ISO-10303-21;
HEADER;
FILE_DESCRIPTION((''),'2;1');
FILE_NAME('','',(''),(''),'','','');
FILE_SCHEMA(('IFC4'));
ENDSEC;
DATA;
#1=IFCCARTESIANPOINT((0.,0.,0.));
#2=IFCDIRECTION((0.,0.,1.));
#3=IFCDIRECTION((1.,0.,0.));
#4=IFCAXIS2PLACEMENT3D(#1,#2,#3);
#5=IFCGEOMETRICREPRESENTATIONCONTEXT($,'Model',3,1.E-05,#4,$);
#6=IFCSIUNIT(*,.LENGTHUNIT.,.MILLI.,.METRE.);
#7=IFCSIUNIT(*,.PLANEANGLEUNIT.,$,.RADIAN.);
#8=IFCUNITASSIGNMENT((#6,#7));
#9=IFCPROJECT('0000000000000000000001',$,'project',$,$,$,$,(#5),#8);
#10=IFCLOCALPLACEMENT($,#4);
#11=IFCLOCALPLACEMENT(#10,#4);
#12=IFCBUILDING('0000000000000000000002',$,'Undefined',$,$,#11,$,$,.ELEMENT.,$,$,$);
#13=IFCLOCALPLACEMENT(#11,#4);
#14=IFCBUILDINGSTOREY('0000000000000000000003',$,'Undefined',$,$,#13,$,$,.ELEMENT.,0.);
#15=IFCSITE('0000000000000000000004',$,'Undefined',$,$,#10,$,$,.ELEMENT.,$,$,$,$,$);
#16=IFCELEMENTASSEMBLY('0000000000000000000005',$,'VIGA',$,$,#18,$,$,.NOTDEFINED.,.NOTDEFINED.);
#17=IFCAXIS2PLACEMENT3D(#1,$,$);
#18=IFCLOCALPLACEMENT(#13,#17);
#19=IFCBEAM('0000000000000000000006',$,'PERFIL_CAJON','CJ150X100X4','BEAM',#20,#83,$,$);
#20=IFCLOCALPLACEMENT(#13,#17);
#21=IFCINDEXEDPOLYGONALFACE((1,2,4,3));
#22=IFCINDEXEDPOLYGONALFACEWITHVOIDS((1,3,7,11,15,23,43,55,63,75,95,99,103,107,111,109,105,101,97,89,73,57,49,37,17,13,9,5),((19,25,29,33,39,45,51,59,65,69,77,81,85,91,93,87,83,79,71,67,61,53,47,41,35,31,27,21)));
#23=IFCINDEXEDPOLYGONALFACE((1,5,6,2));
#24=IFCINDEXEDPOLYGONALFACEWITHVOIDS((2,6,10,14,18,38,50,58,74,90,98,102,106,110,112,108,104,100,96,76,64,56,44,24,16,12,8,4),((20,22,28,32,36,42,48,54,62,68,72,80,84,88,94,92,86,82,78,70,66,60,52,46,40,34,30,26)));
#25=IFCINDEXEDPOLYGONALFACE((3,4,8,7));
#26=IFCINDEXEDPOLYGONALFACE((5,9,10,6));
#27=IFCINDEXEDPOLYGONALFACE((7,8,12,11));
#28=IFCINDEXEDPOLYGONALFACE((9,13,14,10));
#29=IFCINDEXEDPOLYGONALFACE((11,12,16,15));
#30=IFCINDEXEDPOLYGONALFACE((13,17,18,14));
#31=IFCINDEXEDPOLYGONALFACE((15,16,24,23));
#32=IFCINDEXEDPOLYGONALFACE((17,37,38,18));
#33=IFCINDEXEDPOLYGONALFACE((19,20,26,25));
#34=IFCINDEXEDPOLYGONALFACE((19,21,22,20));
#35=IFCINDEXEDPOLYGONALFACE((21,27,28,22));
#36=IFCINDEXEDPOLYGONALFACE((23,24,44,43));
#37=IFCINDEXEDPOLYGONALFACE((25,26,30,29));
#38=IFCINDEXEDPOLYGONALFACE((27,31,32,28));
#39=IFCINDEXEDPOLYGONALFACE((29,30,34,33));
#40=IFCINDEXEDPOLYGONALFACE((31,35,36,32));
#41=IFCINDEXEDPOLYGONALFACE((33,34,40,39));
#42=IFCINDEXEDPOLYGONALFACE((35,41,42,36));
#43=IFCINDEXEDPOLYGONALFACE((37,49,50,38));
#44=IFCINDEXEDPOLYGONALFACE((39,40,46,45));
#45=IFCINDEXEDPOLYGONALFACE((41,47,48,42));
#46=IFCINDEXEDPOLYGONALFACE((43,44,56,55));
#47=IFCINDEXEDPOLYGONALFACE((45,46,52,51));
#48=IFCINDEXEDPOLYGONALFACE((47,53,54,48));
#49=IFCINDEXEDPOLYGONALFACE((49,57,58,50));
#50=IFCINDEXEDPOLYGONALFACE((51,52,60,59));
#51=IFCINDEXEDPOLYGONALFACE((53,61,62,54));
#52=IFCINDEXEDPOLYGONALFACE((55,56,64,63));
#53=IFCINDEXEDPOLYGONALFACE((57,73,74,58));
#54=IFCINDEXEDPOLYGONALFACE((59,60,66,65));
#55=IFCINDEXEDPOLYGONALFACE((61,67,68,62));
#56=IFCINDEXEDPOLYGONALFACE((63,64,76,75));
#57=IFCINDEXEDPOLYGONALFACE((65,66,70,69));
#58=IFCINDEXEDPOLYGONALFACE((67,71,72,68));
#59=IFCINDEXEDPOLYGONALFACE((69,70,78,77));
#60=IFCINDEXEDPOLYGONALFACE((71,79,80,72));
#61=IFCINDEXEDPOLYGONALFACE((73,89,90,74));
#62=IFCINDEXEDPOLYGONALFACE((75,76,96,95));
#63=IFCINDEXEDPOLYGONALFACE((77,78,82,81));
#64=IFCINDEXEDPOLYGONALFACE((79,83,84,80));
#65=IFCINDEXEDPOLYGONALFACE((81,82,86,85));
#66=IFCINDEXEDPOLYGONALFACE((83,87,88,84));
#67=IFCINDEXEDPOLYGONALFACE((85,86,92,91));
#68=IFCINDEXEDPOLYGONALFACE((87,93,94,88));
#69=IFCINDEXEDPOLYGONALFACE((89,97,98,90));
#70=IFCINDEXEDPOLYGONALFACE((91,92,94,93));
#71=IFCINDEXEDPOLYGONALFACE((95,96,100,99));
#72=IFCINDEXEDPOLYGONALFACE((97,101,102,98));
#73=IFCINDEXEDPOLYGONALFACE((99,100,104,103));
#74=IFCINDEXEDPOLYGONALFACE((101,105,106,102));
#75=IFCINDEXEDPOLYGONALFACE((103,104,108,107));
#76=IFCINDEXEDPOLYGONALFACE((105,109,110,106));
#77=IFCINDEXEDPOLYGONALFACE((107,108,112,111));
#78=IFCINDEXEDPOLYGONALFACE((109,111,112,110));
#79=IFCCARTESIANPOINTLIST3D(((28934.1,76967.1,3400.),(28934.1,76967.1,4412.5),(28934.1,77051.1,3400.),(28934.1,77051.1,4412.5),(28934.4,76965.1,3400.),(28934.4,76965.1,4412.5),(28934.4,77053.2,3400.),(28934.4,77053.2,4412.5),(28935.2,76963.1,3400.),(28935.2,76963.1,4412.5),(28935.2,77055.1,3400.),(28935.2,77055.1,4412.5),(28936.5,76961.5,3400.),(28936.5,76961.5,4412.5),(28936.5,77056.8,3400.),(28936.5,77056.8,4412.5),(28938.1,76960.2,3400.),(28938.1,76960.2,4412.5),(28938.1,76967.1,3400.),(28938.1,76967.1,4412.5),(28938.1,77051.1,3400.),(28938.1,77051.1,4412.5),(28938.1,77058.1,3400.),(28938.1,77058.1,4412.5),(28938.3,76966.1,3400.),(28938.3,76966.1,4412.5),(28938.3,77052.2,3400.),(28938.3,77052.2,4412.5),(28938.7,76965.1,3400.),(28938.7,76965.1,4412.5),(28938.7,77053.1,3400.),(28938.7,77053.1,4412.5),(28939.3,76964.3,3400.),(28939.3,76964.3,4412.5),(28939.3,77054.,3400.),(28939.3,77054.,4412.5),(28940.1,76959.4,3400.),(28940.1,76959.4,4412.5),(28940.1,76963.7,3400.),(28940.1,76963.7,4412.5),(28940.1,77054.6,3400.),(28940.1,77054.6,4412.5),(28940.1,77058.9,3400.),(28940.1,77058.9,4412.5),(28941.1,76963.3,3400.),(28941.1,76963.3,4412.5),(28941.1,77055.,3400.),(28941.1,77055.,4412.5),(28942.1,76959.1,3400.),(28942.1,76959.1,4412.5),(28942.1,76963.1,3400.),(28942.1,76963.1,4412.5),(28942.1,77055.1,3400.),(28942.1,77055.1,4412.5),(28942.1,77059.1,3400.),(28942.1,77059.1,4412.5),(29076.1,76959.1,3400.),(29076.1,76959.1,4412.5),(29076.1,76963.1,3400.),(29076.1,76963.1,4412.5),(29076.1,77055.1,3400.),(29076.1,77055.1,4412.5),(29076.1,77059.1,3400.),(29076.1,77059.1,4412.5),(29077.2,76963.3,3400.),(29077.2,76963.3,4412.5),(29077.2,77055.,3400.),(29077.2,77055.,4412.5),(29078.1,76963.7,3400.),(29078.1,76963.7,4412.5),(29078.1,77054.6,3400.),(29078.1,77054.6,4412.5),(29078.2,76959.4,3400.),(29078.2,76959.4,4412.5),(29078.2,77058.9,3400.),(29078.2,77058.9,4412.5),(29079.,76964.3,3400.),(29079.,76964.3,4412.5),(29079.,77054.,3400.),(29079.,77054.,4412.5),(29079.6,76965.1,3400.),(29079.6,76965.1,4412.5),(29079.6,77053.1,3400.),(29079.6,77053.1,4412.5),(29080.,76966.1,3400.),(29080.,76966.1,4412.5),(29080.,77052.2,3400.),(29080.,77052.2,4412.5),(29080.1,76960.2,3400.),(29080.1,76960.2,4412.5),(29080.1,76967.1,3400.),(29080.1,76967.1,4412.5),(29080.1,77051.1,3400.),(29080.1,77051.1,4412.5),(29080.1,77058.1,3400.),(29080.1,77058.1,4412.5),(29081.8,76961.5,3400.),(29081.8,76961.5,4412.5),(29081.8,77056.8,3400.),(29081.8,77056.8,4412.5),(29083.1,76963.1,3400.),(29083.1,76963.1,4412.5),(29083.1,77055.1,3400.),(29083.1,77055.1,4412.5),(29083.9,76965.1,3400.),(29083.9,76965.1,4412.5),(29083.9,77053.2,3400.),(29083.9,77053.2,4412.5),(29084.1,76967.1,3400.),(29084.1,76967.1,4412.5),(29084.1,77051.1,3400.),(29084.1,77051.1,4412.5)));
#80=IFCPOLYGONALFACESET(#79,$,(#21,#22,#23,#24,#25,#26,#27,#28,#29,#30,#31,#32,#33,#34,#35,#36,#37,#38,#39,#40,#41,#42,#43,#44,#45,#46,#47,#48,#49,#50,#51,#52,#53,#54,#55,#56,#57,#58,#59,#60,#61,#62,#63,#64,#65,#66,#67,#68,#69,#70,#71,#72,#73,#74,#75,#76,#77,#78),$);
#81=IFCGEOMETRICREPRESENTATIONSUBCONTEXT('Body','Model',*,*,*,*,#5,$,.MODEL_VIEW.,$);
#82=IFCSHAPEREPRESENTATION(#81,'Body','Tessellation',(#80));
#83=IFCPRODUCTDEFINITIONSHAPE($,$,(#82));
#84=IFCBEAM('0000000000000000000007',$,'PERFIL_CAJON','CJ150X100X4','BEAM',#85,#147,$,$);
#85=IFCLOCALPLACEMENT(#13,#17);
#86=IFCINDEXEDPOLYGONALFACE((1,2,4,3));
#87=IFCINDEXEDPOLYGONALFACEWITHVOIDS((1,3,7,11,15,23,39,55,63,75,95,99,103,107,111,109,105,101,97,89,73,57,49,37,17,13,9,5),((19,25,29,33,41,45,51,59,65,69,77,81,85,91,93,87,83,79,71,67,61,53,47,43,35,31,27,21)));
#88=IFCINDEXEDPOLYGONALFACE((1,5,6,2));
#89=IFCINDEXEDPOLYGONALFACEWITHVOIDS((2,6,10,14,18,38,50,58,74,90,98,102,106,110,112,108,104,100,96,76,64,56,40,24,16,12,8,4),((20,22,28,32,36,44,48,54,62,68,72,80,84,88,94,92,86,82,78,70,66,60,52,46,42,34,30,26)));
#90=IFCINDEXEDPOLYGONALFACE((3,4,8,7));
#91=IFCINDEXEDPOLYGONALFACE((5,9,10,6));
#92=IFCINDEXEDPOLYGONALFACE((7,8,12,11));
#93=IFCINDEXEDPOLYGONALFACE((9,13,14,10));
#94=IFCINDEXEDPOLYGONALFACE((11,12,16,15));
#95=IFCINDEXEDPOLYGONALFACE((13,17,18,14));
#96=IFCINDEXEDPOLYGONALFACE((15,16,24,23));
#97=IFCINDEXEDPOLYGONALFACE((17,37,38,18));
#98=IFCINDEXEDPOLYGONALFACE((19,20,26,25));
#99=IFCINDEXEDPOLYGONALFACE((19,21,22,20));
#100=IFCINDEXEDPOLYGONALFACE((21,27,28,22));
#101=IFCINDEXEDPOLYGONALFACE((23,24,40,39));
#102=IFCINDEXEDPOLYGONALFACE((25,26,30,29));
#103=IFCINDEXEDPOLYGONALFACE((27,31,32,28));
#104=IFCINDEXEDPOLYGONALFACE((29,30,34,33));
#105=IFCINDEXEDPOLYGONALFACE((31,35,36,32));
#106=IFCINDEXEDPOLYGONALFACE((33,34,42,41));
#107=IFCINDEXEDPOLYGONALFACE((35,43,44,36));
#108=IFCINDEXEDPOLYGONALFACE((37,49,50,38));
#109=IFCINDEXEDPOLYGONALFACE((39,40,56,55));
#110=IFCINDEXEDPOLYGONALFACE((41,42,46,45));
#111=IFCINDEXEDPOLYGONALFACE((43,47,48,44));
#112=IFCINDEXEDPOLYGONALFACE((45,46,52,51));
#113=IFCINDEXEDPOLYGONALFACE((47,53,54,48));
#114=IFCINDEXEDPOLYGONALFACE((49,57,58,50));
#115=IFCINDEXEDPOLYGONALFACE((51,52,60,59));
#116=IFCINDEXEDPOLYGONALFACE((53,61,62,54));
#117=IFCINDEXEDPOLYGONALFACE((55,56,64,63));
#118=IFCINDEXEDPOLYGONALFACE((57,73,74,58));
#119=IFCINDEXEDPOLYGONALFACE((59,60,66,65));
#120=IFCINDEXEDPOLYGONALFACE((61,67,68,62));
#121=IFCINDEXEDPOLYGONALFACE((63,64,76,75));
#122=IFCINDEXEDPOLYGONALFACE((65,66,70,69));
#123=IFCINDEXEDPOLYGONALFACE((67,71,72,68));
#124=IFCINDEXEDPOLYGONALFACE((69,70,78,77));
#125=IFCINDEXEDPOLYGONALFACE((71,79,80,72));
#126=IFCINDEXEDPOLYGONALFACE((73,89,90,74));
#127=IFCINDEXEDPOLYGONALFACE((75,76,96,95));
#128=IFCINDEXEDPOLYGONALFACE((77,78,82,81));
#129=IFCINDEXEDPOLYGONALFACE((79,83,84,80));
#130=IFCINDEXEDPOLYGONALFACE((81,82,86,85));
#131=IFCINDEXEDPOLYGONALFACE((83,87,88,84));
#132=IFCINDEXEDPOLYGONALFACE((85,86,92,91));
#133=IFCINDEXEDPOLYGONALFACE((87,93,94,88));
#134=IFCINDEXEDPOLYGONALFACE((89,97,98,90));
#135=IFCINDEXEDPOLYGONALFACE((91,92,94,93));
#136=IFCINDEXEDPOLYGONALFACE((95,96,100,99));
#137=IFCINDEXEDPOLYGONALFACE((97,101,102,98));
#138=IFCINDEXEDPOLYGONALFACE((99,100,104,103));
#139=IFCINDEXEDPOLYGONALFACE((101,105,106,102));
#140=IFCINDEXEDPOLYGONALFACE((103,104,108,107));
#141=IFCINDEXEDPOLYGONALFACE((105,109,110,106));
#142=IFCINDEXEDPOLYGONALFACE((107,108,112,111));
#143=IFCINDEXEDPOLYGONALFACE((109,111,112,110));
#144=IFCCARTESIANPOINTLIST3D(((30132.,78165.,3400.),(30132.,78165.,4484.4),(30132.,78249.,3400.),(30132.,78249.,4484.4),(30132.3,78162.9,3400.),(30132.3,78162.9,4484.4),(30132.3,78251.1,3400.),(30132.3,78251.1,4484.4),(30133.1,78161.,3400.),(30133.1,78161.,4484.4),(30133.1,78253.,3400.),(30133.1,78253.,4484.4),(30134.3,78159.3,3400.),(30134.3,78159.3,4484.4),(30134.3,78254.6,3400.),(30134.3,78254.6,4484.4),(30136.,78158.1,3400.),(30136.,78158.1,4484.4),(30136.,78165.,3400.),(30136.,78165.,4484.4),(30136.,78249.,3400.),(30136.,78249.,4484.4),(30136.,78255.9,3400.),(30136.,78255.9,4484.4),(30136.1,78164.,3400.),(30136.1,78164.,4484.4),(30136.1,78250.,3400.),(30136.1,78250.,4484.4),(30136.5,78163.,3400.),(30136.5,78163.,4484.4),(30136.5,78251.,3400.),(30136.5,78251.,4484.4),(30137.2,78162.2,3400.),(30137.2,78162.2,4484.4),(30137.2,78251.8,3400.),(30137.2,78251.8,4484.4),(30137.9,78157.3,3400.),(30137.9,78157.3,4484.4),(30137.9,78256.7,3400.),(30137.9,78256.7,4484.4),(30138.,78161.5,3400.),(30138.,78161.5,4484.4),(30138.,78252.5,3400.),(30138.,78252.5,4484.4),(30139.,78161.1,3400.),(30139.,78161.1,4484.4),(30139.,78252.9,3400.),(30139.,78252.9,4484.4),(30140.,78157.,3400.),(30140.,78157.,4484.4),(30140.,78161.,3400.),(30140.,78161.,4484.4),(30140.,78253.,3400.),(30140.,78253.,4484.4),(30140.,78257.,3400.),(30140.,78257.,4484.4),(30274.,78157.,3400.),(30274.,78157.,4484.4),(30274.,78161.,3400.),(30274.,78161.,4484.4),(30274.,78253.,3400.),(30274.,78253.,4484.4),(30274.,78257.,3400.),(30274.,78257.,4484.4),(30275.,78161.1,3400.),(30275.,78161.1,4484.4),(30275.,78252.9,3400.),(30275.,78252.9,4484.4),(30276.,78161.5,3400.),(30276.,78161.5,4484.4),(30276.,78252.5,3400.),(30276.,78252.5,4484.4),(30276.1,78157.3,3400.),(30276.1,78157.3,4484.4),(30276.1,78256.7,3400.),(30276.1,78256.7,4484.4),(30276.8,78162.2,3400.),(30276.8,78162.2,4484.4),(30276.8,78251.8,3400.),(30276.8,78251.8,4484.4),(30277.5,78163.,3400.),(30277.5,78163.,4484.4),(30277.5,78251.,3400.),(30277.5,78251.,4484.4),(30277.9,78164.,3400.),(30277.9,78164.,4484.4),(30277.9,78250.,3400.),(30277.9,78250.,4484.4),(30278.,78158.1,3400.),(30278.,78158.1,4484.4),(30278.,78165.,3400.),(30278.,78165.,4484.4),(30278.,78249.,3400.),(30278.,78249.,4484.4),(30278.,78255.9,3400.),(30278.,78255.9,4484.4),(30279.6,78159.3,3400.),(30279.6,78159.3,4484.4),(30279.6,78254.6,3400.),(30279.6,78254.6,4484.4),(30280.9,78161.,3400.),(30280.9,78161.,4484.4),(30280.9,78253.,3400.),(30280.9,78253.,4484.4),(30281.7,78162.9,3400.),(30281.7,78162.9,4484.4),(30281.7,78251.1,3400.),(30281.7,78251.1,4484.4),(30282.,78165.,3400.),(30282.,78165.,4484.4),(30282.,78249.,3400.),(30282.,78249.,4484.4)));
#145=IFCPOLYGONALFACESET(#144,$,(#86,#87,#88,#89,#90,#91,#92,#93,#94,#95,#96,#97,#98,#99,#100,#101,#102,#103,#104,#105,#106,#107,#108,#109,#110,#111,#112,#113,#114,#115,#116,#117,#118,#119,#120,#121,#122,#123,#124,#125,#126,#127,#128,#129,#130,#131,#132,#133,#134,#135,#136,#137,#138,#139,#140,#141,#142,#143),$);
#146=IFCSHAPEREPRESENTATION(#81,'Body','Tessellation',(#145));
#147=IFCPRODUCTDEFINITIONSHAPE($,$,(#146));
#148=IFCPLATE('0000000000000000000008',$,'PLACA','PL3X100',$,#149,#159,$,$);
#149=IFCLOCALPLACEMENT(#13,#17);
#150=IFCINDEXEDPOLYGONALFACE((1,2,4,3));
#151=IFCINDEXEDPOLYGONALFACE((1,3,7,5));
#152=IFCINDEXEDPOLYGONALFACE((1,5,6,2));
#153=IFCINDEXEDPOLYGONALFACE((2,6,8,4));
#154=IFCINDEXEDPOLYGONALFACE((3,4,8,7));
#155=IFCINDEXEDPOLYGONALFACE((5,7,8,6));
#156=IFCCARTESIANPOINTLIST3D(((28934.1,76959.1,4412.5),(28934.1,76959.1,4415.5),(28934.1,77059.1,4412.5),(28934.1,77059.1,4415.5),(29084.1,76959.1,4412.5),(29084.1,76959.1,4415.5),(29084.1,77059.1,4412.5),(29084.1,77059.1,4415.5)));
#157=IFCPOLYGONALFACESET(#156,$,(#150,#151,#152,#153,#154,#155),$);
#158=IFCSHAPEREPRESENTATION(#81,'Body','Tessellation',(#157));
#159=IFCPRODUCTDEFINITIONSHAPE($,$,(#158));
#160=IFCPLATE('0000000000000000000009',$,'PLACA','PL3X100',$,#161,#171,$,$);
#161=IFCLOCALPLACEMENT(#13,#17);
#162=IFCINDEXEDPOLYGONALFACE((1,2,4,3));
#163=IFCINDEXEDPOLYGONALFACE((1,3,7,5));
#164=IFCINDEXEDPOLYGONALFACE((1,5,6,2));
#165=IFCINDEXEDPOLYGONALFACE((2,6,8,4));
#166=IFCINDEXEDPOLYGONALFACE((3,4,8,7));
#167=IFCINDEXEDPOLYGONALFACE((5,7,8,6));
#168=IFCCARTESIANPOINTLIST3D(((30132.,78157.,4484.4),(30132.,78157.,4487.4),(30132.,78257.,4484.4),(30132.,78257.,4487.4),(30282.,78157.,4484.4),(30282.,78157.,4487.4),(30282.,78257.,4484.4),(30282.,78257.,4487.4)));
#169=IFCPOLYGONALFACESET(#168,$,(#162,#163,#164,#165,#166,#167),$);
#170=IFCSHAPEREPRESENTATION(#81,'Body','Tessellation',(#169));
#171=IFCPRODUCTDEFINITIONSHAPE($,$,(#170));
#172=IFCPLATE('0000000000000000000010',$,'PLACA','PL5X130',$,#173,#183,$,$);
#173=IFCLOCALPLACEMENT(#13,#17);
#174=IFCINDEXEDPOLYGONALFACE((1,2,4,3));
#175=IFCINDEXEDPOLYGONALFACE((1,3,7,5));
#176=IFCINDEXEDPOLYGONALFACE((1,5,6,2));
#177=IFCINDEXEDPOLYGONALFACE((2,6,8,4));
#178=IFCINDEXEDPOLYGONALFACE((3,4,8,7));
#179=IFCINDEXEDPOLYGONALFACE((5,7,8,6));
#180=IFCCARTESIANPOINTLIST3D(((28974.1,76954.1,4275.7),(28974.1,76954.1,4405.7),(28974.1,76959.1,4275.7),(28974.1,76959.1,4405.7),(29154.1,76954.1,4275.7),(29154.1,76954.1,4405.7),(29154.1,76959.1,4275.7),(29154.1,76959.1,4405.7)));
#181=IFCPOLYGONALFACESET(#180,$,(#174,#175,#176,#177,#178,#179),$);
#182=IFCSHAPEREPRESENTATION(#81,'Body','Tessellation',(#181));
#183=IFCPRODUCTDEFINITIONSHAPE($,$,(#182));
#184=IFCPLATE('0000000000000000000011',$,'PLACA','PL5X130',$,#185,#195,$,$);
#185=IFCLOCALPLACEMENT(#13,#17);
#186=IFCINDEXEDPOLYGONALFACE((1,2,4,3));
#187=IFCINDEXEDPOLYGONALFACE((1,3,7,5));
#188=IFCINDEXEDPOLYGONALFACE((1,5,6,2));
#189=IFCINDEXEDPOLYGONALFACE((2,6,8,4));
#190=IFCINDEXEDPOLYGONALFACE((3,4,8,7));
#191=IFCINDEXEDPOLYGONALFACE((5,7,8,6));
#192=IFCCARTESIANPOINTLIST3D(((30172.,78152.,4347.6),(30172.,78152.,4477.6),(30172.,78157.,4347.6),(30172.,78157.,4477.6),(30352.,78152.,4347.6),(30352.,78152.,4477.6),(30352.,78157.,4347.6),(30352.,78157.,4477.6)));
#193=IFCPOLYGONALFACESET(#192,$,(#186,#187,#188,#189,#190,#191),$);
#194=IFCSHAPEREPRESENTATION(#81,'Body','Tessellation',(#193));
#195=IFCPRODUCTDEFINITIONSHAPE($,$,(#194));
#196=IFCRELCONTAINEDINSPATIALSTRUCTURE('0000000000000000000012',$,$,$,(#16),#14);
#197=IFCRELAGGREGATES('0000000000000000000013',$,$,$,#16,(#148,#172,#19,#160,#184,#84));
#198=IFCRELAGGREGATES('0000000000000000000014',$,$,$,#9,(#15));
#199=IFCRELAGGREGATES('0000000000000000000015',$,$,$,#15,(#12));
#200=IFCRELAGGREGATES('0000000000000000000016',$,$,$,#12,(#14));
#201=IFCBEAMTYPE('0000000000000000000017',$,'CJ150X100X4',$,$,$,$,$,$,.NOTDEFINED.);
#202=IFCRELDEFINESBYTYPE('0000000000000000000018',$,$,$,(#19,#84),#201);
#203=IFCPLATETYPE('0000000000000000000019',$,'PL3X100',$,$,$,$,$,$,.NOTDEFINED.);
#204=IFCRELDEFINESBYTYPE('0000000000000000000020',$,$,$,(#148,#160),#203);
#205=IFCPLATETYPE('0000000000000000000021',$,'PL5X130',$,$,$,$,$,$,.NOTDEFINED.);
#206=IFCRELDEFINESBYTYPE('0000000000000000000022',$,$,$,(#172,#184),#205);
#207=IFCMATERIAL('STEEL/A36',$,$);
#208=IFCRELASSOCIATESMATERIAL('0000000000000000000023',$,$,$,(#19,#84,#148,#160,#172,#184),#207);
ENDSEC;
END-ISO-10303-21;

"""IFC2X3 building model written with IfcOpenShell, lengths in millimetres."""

from ifc_helpers import new_model, si_unit, frame, origin_with_axes, origin_2d_with_axis, place, context, subcontext, project, spatial, polyline, hollow_rectangle, outline, extrude, material, type_object, element, aggregate, save


model = new_model("IFC2X3")

# Units and contexts
model_context = context("Model", 3, precision=1e-05, world=origin_with_axes())
body_context = subcontext(model_context, "Body", "Model", "MODEL_VIEW")
ifc_project = project(units=[si_unit("LENGTHUNIT", "METRE", prefix="MILLI"), si_unit("PLANEANGLEUNIT", "RADIAN")], contexts=[model_context])

# Site, building, storey
site_placement = place(None, origin_with_axes())
site = spatial("IfcSite", under=ifc_project, at=site_placement, Name="Undefined", CompositionType="ELEMENT")
building_placement = place(site_placement, origin_with_axes())
building = spatial("IfcBuilding", under=site, at=building_placement, Name="Undefined", CompositionType="ELEMENT")
storey_placement = place(building_placement, origin_with_axes())
storey = spatial("IfcBuildingStorey", under=building, at=storey_placement, Name="Undefined", CompositionType="ELEMENT", Elevation=0.0)

# Element assembly, beams
assembly_1_placement = place(storey_placement, origin_with_axes())
assembly_1 = element("IfcElementAssembly", 1, at=assembly_1_placement, inside=storey, Name="VIGA", AssemblyPlace="NOTDEFINED", PredefinedType="NOTDEFINED")
ifc_material_1 = material(Name="STEEL/A36")
beam_type = type_object("IfcBeamType", Name="CJ150X100X4", PredefinedType="NOTDEFINED")
beam_1_placement = place(assembly_1_placement, frame((29009.1, 77009.1, 4412.5), z_axis=(1.0, 0.0, 0.0), x_axis=(0.0, 0.0, -1.0)))
beam_1 = element("IfcBeam", 2, at=beam_1_placement, type_object=beam_type, material=ifc_material_1, Name="PERFIL_CAJON", Description="CJ150X100X4", ObjectType="BEAM", context=body_context, shape_type="SweptSolid", body=[
    extrude(hollow_rectangle(XDim=100.0, YDim=150.0, WallThickness=4.0, InnerFilletRadius=4.0, OuterFilletRadius=8.0, at=origin_2d_with_axis()), frame((1012.5, 0.0, 0.0), z_axis=(-1.0, 0.0, 0.0), x_axis=(0.0, -1.0, 0.0)), (0.0, 0.0, 1.0), 1012.5),
])
beam_2_placement = place(assembly_1_placement, frame((30207.0, 78207.0, 4484.4), z_axis=(1.0, 0.0, 0.0), x_axis=(0.0, 0.0, -1.0)))
beam_2 = element("IfcBeam", 3, at=beam_2_placement, type_object=beam_type, material=ifc_material_1, Name="PERFIL_CAJON", Description="CJ150X100X4", ObjectType="BEAM", context=body_context, shape_type="SweptSolid", body=[
    extrude(hollow_rectangle(XDim=100.0, YDim=150.0, WallThickness=4.0, InnerFilletRadius=4.0, OuterFilletRadius=8.0, at=origin_2d_with_axis()), frame((1084.4, 0.0, 0.0), z_axis=(-1.0, 0.0, 0.0), x_axis=(0.0, -1.0, 0.0)), (0.0, 0.0, 1.0), 1084.4),
])

# Plates
plate_type_1 = type_object("IfcPlateType", Name="PL3X100", PredefinedType="NOTDEFINED")
plate_1_placement = place(assembly_1_placement, frame((28934.1, 76959.1, 4414.0), z_axis=(0.0, 0.0, -1.0), x_axis=(0.0, 1.0, 0.0)))
plate_1 = element("IfcPlate", 4, at=plate_1_placement, type_object=plate_type_1, material=ifc_material_1, Name="PLACA", Description="PL3X100", context=body_context, shape_type="SweptSolid", body=[
    extrude(outline(polyline([(0.0, 0.0), (100.0, 0.0), (100.0, 150.0), (0.0, 150.0), (0.0, 0.0)])), frame((0.0, 0.0, -1.5), z_axis=(0.0, 0.0, 1.0), x_axis=(1.0, 0.0, 0.0)), (0.0, 0.0, 1.0), 3.0),
])
plate_2_placement = place(assembly_1_placement, frame((30132.0, 78157.0, 4485.9), z_axis=(0.0, 0.0, -1.0), x_axis=(0.0, 1.0, 0.0)))
plate_2 = element("IfcPlate", 5, at=plate_2_placement, type_object=plate_type_1, material=ifc_material_1, Name="PLACA", Description="PL3X100", context=body_context, shape_type="SweptSolid", body=[
    extrude(outline(polyline([(0.0, 0.0), (100.0, 0.0), (100.0, 150.0), (0.0, 150.0), (0.0, 0.0)])), frame((0.0, 0.0, -1.5), z_axis=(0.0, 0.0, 1.0), x_axis=(1.0, 0.0, 0.0)), (0.0, 0.0, 1.0), 3.0),
])
plate_type_2 = type_object("IfcPlateType", Name="PL5X130", PredefinedType="NOTDEFINED")
plate_3_placement = place(assembly_1_placement, frame((29154.1, 76956.6, 4405.7), z_axis=(0.0, -1.0, 0.0), x_axis=(-1.0, 0.0, 0.0)))
plate_3 = element("IfcPlate", 6, at=plate_3_placement, type_object=plate_type_2, material=ifc_material_1, Name="PLACA", Description="PL5X130", context=body_context, shape_type="SweptSolid", body=[
    extrude(outline(polyline([(0.0, 0.0), (180.0, 0.0), (180.0, 130.0), (0.0, 130.0), (0.0, 0.0)])), frame((0.0, 0.0, -2.5), z_axis=(0.0, 0.0, 1.0), x_axis=(1.0, 0.0, 0.0)), (0.0, 0.0, 1.0), 5.0),
])
plate_4_placement = place(assembly_1_placement, frame((30352.0, 78154.5, 4477.6), z_axis=(0.0, -1.0, 0.0), x_axis=(-1.0, 0.0, 0.0)))
plate_4 = element("IfcPlate", 7, at=plate_4_placement, type_object=plate_type_2, material=ifc_material_1, Name="PLACA", Description="PL5X130", context=body_context, shape_type="SweptSolid", body=[
    extrude(outline(polyline([(0.0, 0.0), (180.0, 0.0), (180.0, 130.0), (0.0, 130.0), (0.0, 0.0)])), frame((0.0, 0.0, -2.5), z_axis=(0.0, 0.0, 1.0), x_axis=(1.0, 0.0, 0.0)), (0.0, 0.0, 1.0), 5.0),
])

aggregate(assembly_1, [plate_1, plate_3, beam_1, plate_2, plate_4, beam_2])

save(model, "model.ifc")
